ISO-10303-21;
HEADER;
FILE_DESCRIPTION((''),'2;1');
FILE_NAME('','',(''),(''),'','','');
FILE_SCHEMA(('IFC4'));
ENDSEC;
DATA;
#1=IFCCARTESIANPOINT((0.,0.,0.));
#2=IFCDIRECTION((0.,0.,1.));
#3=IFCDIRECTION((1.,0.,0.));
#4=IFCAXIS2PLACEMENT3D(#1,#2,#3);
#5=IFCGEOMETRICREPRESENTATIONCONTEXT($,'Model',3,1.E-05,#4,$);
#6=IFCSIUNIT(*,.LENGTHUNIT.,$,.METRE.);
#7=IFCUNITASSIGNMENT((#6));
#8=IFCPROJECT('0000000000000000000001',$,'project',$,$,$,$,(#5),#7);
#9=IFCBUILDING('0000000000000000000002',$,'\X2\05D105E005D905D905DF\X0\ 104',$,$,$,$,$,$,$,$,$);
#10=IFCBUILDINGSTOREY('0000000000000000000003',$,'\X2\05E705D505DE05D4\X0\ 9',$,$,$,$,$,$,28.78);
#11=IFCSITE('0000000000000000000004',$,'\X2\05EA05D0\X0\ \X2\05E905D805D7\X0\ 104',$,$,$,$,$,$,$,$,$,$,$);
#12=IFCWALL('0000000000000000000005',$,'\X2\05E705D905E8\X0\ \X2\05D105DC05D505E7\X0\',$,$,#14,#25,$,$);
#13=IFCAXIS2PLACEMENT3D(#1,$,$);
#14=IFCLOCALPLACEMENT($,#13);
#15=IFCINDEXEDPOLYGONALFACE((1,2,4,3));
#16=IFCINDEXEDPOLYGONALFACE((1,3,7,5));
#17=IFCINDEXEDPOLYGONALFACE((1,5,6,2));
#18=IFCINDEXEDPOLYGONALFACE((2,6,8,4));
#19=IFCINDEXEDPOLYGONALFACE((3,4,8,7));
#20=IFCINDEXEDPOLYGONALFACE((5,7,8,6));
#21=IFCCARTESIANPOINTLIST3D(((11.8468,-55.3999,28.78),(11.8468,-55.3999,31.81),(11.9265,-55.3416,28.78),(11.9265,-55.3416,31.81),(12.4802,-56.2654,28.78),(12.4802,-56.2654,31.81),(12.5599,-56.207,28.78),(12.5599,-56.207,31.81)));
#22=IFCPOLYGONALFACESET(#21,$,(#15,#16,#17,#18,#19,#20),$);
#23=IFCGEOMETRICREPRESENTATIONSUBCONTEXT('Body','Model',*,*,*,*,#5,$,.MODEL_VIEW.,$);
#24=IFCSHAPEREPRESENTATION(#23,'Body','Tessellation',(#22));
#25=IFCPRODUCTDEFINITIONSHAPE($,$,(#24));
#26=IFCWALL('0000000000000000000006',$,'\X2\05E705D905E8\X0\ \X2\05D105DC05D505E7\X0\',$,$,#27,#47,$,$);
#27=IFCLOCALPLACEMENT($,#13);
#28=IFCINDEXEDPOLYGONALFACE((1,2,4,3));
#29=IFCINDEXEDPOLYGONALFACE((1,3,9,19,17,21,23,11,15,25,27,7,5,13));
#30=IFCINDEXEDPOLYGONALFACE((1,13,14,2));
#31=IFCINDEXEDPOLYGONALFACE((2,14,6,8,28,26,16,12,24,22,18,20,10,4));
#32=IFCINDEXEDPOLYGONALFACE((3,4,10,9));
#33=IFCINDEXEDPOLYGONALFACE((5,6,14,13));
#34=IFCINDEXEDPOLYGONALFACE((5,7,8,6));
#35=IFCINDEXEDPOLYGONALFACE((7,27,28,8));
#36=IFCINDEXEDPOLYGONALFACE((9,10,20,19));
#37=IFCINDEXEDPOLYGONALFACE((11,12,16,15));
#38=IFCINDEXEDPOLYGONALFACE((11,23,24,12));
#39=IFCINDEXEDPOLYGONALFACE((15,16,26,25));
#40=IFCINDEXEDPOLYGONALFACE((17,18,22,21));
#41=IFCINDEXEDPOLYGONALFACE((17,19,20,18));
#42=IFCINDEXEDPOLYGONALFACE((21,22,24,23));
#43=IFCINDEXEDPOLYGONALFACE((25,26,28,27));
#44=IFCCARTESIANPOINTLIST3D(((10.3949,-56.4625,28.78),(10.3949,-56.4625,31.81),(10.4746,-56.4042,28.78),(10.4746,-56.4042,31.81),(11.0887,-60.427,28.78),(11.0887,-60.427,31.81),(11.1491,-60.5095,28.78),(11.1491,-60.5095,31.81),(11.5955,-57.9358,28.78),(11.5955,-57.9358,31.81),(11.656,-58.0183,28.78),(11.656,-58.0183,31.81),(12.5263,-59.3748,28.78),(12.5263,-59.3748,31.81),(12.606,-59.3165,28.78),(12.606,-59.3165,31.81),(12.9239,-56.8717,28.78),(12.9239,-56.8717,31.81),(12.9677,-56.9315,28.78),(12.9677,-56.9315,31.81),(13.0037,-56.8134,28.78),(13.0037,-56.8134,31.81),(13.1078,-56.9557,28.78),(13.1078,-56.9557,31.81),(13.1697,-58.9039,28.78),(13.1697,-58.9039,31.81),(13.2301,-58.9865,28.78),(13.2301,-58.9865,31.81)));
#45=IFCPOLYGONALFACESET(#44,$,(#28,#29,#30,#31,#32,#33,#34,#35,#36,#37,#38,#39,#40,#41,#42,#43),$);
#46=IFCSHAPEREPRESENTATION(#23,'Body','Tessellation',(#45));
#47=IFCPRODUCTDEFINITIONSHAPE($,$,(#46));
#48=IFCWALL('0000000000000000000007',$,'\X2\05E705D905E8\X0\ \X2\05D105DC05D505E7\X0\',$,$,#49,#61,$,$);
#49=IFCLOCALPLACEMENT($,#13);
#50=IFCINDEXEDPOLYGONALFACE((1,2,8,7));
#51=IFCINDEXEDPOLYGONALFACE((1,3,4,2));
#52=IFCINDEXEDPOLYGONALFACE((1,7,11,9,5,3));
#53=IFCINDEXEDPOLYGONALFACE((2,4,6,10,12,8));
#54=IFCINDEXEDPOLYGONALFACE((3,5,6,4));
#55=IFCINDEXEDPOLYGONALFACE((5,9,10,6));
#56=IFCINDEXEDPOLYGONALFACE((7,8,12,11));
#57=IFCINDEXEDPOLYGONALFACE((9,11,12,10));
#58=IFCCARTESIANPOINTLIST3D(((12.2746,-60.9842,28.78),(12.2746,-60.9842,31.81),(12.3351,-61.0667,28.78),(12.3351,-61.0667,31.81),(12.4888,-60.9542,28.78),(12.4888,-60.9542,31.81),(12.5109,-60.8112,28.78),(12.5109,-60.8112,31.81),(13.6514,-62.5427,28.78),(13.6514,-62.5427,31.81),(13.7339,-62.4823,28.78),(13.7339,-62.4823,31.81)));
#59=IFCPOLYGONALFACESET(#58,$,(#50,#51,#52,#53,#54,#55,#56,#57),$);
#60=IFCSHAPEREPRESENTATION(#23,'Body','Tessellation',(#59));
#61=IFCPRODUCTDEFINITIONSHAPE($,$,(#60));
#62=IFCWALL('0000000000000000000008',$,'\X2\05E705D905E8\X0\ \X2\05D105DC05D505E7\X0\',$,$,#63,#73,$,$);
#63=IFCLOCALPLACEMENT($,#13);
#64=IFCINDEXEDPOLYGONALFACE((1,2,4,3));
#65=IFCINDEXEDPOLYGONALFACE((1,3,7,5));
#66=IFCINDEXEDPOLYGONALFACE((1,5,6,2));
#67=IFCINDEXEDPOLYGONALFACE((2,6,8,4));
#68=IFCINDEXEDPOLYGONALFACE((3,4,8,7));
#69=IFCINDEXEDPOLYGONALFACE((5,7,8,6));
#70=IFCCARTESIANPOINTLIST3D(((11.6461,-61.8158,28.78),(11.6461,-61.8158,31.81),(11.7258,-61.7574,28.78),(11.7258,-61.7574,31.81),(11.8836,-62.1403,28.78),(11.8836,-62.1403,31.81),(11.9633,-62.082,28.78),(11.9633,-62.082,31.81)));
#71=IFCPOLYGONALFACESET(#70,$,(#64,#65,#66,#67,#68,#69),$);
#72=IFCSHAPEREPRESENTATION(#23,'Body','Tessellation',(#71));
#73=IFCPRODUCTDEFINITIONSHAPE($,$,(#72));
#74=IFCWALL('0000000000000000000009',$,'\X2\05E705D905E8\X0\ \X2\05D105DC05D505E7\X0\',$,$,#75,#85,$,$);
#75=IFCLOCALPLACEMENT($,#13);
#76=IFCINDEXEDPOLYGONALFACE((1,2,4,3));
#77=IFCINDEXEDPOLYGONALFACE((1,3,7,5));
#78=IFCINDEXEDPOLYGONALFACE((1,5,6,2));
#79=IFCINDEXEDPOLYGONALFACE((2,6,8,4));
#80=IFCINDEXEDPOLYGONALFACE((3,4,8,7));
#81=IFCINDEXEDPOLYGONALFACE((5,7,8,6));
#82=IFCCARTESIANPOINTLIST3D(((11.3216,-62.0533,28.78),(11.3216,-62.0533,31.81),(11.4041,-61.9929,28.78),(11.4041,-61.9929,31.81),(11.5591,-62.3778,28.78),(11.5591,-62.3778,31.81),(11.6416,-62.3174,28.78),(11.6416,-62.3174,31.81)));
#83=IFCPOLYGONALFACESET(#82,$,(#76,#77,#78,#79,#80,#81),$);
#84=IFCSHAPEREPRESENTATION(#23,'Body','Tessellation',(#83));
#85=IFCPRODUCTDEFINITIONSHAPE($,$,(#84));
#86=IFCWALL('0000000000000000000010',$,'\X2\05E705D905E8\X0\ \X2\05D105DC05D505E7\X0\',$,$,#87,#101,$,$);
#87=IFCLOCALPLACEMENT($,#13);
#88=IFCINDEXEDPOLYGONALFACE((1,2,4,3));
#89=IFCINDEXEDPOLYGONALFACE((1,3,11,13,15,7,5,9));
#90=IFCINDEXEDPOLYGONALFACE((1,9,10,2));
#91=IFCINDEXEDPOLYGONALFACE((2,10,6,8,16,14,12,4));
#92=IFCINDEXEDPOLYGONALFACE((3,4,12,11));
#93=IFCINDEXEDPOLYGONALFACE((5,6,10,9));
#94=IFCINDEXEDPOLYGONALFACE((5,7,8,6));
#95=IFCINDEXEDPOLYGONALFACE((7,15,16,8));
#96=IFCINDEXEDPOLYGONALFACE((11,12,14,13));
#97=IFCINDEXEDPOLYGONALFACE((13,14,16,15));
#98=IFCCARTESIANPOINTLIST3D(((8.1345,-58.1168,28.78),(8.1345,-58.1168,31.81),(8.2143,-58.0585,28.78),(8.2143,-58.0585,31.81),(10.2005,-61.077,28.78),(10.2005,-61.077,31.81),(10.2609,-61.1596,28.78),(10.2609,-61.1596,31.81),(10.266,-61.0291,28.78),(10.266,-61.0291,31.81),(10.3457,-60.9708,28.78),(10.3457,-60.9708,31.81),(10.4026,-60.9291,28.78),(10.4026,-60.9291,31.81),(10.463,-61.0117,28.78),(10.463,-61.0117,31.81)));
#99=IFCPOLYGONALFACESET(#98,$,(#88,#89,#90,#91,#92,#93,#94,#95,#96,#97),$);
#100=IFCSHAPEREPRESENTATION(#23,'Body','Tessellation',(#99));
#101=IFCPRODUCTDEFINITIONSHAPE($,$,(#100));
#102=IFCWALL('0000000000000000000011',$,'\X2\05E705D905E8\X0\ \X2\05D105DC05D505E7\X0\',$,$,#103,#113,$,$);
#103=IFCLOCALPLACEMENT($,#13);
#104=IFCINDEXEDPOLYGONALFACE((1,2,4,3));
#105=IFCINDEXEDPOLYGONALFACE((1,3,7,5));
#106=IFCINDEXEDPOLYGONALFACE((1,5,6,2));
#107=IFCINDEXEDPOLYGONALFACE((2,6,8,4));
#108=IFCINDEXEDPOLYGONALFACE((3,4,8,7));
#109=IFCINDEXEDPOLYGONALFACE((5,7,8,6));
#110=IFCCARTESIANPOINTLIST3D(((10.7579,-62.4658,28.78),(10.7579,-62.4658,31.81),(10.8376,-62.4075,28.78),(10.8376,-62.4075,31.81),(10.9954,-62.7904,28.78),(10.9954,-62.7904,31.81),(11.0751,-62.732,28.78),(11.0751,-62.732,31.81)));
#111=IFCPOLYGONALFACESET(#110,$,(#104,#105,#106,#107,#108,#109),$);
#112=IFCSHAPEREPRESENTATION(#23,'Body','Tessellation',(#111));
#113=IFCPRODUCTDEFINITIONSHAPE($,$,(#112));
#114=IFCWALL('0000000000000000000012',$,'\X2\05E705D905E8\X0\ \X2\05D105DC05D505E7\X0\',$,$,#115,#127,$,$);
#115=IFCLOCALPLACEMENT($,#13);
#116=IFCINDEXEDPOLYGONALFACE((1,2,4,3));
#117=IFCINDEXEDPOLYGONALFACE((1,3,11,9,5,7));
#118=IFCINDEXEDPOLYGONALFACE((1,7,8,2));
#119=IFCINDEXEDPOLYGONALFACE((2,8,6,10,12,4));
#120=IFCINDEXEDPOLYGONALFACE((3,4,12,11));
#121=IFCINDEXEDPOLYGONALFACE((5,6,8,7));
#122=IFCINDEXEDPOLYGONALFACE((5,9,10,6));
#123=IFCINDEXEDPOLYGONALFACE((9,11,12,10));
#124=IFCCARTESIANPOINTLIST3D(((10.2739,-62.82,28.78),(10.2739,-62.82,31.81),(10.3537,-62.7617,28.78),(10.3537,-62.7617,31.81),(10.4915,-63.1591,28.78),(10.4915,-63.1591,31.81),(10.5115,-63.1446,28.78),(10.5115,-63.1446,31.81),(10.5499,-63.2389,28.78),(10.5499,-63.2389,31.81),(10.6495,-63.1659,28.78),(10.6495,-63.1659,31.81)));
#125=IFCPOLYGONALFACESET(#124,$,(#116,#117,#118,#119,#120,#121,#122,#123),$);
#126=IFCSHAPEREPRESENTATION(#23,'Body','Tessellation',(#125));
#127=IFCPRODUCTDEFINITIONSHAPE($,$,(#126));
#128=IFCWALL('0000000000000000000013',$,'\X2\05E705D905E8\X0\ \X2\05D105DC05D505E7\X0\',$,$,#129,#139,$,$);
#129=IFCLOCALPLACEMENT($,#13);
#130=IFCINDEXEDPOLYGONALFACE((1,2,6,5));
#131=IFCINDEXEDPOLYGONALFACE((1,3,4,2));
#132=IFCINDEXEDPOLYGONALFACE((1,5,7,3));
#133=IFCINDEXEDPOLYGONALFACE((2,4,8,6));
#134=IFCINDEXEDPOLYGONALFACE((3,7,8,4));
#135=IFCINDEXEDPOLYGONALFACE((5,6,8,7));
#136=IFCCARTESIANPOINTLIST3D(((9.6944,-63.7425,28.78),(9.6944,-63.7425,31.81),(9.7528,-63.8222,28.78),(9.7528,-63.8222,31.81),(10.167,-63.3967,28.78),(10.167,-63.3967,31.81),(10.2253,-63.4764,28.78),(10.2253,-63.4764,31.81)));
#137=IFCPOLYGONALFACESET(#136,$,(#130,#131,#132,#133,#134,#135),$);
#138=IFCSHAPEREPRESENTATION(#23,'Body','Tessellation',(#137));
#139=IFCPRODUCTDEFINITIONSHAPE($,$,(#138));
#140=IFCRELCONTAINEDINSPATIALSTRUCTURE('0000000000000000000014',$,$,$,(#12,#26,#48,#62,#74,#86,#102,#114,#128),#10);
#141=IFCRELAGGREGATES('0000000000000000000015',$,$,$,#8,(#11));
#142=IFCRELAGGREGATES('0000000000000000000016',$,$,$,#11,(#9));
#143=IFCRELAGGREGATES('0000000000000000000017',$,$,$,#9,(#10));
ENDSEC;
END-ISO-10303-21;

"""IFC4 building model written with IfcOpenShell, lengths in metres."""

from ifc_helpers import new_model, si_unit, frame, origin_with_axes, context, subcontext, project, spatial, polyline, outline, extrude, element, save


model = new_model("IFC4")

# Units and contexts
model_context = context("Model", 3, precision=1e-05, world=origin_with_axes())
body_context = subcontext(model_context, "Body", "Model", "MODEL_VIEW")
ifc_project = project(units=[si_unit("LENGTHUNIT", "METRE")], contexts=[model_context])

# Site, building, storey
site = spatial("IfcSite", under=ifc_project, Name="תא שטח 104")
building = spatial("IfcBuilding", under=site, Name="בניין 104")
storey = spatial("IfcBuildingStorey", under=building, Name="קומה 9", Elevation=28.78)

# Walls
element("IfcWall", 1, inside=storey, Name="קיר בלוק", context=body_context, shape_type="SweptSolid", body=[
    extrude(outline(polyline([(12.5599, -56.207), (11.9265, -55.3416), (11.8468, -55.3999), (12.4802, -56.2654), (12.5599, -56.207)])), frame((0.0, 0.0, 28.78)), (0.0, 0.0, 1.0), 3.03),
])
element("IfcWall", 2, inside=storey, Name="קיר בלוק", context=body_context, shape_type="SweptSolid", body=[
    extrude(outline(polyline([(11.5955, -57.9358), (10.4746, -56.4042), (10.3949, -56.4625), (12.5263, -59.3748), (11.0887, -60.427), (11.1491, -60.5095), (13.2301, -58.9865), (13.1697, -58.9039), (12.606, -59.3165), (11.656, -58.0183), (13.1078, -56.9557), (13.0037, -56.8134), (12.9239, -56.8717), (12.9677, -56.9315), (11.5955, -57.9358)])), frame((0.0, 0.0, 28.78)), (0.0, 0.0, 1.0), 3.03),
])
element("IfcWall", 3, inside=storey, Name="קיר בלוק", context=body_context, shape_type="SweptSolid", body=[
    extrude(outline(polyline([(12.2746, -60.9842), (12.3351, -61.0667), (12.4888, -60.9542), (13.6514, -62.5427), (13.7339, -62.4823), (12.5109, -60.8112), (12.2746, -60.9842)])), frame((0.0, 0.0, 28.78)), (0.0, 0.0, 1.0), 3.03),
])
element("IfcWall", 4, inside=storey, Name="קיר בלוק", context=body_context, shape_type="SweptSolid", body=[
    extrude(outline(polyline([(11.8836, -62.1403), (11.9633, -62.082), (11.7258, -61.7574), (11.6461, -61.8158), (11.8836, -62.1403)])), frame((0.0, 0.0, 28.78)), (0.0, 0.0, 1.0), 3.03),
])
element("IfcWall", 5, inside=storey, Name="קיר בלוק", context=body_context, shape_type="SweptSolid", body=[
    extrude(outline(polyline([(11.4041, -61.9929), (11.3216, -62.0533), (11.5591, -62.3778), (11.6416, -62.3174), (11.4041, -61.9929)])), frame((0.0, 0.0, 28.78)), (0.0, 0.0, 1.0), 3.03),
])
element("IfcWall", 6, inside=storey, Name="קיר בלוק", context=body_context, shape_type="SweptSolid", body=[
    extrude(outline(polyline([(10.266, -61.0291), (10.2005, -61.077), (10.2609, -61.1596), (10.463, -61.0117), (10.4026, -60.9291), (10.3457, -60.9708), (8.2143, -58.0585), (8.1345, -58.1168), (10.266, -61.0291)])), frame((0.0, 0.0, 28.78)), (0.0, 0.0, 1.0), 3.03),
])
element("IfcWall", 7, inside=storey, Name="קיר בלוק", context=body_context, shape_type="SweptSolid", body=[
    extrude(outline(polyline([(10.8376, -62.4075), (10.7579, -62.4658), (10.9954, -62.7904), (11.0751, -62.732), (10.8376, -62.4075)])), frame((0.0, 0.0, 28.78)), (0.0, 0.0, 1.0), 3.03),
])
element("IfcWall", 8, inside=storey, Name="קיר בלוק", context=body_context, shape_type="SweptSolid", body=[
    extrude(outline(polyline([(10.6495, -63.1659), (10.3537, -62.7617), (10.2739, -62.82), (10.5115, -63.1446), (10.4915, -63.1591), (10.5499, -63.2389), (10.6495, -63.1659)])), frame((0.0, 0.0, 28.78)), (0.0, 0.0, 1.0), 3.03),
])
element("IfcWall", 9, inside=storey, Name="קיר בלוק", context=body_context, shape_type="SweptSolid", body=[
    extrude(outline(polyline([(10.2253, -63.4764), (10.167, -63.3967), (9.6944, -63.7425), (9.7528, -63.8222), (10.2253, -63.4764)])), frame((0.0, 0.0, 28.78)), (0.0, 0.0, 1.0), 3.03),
])

save(model, "model.ifc")
